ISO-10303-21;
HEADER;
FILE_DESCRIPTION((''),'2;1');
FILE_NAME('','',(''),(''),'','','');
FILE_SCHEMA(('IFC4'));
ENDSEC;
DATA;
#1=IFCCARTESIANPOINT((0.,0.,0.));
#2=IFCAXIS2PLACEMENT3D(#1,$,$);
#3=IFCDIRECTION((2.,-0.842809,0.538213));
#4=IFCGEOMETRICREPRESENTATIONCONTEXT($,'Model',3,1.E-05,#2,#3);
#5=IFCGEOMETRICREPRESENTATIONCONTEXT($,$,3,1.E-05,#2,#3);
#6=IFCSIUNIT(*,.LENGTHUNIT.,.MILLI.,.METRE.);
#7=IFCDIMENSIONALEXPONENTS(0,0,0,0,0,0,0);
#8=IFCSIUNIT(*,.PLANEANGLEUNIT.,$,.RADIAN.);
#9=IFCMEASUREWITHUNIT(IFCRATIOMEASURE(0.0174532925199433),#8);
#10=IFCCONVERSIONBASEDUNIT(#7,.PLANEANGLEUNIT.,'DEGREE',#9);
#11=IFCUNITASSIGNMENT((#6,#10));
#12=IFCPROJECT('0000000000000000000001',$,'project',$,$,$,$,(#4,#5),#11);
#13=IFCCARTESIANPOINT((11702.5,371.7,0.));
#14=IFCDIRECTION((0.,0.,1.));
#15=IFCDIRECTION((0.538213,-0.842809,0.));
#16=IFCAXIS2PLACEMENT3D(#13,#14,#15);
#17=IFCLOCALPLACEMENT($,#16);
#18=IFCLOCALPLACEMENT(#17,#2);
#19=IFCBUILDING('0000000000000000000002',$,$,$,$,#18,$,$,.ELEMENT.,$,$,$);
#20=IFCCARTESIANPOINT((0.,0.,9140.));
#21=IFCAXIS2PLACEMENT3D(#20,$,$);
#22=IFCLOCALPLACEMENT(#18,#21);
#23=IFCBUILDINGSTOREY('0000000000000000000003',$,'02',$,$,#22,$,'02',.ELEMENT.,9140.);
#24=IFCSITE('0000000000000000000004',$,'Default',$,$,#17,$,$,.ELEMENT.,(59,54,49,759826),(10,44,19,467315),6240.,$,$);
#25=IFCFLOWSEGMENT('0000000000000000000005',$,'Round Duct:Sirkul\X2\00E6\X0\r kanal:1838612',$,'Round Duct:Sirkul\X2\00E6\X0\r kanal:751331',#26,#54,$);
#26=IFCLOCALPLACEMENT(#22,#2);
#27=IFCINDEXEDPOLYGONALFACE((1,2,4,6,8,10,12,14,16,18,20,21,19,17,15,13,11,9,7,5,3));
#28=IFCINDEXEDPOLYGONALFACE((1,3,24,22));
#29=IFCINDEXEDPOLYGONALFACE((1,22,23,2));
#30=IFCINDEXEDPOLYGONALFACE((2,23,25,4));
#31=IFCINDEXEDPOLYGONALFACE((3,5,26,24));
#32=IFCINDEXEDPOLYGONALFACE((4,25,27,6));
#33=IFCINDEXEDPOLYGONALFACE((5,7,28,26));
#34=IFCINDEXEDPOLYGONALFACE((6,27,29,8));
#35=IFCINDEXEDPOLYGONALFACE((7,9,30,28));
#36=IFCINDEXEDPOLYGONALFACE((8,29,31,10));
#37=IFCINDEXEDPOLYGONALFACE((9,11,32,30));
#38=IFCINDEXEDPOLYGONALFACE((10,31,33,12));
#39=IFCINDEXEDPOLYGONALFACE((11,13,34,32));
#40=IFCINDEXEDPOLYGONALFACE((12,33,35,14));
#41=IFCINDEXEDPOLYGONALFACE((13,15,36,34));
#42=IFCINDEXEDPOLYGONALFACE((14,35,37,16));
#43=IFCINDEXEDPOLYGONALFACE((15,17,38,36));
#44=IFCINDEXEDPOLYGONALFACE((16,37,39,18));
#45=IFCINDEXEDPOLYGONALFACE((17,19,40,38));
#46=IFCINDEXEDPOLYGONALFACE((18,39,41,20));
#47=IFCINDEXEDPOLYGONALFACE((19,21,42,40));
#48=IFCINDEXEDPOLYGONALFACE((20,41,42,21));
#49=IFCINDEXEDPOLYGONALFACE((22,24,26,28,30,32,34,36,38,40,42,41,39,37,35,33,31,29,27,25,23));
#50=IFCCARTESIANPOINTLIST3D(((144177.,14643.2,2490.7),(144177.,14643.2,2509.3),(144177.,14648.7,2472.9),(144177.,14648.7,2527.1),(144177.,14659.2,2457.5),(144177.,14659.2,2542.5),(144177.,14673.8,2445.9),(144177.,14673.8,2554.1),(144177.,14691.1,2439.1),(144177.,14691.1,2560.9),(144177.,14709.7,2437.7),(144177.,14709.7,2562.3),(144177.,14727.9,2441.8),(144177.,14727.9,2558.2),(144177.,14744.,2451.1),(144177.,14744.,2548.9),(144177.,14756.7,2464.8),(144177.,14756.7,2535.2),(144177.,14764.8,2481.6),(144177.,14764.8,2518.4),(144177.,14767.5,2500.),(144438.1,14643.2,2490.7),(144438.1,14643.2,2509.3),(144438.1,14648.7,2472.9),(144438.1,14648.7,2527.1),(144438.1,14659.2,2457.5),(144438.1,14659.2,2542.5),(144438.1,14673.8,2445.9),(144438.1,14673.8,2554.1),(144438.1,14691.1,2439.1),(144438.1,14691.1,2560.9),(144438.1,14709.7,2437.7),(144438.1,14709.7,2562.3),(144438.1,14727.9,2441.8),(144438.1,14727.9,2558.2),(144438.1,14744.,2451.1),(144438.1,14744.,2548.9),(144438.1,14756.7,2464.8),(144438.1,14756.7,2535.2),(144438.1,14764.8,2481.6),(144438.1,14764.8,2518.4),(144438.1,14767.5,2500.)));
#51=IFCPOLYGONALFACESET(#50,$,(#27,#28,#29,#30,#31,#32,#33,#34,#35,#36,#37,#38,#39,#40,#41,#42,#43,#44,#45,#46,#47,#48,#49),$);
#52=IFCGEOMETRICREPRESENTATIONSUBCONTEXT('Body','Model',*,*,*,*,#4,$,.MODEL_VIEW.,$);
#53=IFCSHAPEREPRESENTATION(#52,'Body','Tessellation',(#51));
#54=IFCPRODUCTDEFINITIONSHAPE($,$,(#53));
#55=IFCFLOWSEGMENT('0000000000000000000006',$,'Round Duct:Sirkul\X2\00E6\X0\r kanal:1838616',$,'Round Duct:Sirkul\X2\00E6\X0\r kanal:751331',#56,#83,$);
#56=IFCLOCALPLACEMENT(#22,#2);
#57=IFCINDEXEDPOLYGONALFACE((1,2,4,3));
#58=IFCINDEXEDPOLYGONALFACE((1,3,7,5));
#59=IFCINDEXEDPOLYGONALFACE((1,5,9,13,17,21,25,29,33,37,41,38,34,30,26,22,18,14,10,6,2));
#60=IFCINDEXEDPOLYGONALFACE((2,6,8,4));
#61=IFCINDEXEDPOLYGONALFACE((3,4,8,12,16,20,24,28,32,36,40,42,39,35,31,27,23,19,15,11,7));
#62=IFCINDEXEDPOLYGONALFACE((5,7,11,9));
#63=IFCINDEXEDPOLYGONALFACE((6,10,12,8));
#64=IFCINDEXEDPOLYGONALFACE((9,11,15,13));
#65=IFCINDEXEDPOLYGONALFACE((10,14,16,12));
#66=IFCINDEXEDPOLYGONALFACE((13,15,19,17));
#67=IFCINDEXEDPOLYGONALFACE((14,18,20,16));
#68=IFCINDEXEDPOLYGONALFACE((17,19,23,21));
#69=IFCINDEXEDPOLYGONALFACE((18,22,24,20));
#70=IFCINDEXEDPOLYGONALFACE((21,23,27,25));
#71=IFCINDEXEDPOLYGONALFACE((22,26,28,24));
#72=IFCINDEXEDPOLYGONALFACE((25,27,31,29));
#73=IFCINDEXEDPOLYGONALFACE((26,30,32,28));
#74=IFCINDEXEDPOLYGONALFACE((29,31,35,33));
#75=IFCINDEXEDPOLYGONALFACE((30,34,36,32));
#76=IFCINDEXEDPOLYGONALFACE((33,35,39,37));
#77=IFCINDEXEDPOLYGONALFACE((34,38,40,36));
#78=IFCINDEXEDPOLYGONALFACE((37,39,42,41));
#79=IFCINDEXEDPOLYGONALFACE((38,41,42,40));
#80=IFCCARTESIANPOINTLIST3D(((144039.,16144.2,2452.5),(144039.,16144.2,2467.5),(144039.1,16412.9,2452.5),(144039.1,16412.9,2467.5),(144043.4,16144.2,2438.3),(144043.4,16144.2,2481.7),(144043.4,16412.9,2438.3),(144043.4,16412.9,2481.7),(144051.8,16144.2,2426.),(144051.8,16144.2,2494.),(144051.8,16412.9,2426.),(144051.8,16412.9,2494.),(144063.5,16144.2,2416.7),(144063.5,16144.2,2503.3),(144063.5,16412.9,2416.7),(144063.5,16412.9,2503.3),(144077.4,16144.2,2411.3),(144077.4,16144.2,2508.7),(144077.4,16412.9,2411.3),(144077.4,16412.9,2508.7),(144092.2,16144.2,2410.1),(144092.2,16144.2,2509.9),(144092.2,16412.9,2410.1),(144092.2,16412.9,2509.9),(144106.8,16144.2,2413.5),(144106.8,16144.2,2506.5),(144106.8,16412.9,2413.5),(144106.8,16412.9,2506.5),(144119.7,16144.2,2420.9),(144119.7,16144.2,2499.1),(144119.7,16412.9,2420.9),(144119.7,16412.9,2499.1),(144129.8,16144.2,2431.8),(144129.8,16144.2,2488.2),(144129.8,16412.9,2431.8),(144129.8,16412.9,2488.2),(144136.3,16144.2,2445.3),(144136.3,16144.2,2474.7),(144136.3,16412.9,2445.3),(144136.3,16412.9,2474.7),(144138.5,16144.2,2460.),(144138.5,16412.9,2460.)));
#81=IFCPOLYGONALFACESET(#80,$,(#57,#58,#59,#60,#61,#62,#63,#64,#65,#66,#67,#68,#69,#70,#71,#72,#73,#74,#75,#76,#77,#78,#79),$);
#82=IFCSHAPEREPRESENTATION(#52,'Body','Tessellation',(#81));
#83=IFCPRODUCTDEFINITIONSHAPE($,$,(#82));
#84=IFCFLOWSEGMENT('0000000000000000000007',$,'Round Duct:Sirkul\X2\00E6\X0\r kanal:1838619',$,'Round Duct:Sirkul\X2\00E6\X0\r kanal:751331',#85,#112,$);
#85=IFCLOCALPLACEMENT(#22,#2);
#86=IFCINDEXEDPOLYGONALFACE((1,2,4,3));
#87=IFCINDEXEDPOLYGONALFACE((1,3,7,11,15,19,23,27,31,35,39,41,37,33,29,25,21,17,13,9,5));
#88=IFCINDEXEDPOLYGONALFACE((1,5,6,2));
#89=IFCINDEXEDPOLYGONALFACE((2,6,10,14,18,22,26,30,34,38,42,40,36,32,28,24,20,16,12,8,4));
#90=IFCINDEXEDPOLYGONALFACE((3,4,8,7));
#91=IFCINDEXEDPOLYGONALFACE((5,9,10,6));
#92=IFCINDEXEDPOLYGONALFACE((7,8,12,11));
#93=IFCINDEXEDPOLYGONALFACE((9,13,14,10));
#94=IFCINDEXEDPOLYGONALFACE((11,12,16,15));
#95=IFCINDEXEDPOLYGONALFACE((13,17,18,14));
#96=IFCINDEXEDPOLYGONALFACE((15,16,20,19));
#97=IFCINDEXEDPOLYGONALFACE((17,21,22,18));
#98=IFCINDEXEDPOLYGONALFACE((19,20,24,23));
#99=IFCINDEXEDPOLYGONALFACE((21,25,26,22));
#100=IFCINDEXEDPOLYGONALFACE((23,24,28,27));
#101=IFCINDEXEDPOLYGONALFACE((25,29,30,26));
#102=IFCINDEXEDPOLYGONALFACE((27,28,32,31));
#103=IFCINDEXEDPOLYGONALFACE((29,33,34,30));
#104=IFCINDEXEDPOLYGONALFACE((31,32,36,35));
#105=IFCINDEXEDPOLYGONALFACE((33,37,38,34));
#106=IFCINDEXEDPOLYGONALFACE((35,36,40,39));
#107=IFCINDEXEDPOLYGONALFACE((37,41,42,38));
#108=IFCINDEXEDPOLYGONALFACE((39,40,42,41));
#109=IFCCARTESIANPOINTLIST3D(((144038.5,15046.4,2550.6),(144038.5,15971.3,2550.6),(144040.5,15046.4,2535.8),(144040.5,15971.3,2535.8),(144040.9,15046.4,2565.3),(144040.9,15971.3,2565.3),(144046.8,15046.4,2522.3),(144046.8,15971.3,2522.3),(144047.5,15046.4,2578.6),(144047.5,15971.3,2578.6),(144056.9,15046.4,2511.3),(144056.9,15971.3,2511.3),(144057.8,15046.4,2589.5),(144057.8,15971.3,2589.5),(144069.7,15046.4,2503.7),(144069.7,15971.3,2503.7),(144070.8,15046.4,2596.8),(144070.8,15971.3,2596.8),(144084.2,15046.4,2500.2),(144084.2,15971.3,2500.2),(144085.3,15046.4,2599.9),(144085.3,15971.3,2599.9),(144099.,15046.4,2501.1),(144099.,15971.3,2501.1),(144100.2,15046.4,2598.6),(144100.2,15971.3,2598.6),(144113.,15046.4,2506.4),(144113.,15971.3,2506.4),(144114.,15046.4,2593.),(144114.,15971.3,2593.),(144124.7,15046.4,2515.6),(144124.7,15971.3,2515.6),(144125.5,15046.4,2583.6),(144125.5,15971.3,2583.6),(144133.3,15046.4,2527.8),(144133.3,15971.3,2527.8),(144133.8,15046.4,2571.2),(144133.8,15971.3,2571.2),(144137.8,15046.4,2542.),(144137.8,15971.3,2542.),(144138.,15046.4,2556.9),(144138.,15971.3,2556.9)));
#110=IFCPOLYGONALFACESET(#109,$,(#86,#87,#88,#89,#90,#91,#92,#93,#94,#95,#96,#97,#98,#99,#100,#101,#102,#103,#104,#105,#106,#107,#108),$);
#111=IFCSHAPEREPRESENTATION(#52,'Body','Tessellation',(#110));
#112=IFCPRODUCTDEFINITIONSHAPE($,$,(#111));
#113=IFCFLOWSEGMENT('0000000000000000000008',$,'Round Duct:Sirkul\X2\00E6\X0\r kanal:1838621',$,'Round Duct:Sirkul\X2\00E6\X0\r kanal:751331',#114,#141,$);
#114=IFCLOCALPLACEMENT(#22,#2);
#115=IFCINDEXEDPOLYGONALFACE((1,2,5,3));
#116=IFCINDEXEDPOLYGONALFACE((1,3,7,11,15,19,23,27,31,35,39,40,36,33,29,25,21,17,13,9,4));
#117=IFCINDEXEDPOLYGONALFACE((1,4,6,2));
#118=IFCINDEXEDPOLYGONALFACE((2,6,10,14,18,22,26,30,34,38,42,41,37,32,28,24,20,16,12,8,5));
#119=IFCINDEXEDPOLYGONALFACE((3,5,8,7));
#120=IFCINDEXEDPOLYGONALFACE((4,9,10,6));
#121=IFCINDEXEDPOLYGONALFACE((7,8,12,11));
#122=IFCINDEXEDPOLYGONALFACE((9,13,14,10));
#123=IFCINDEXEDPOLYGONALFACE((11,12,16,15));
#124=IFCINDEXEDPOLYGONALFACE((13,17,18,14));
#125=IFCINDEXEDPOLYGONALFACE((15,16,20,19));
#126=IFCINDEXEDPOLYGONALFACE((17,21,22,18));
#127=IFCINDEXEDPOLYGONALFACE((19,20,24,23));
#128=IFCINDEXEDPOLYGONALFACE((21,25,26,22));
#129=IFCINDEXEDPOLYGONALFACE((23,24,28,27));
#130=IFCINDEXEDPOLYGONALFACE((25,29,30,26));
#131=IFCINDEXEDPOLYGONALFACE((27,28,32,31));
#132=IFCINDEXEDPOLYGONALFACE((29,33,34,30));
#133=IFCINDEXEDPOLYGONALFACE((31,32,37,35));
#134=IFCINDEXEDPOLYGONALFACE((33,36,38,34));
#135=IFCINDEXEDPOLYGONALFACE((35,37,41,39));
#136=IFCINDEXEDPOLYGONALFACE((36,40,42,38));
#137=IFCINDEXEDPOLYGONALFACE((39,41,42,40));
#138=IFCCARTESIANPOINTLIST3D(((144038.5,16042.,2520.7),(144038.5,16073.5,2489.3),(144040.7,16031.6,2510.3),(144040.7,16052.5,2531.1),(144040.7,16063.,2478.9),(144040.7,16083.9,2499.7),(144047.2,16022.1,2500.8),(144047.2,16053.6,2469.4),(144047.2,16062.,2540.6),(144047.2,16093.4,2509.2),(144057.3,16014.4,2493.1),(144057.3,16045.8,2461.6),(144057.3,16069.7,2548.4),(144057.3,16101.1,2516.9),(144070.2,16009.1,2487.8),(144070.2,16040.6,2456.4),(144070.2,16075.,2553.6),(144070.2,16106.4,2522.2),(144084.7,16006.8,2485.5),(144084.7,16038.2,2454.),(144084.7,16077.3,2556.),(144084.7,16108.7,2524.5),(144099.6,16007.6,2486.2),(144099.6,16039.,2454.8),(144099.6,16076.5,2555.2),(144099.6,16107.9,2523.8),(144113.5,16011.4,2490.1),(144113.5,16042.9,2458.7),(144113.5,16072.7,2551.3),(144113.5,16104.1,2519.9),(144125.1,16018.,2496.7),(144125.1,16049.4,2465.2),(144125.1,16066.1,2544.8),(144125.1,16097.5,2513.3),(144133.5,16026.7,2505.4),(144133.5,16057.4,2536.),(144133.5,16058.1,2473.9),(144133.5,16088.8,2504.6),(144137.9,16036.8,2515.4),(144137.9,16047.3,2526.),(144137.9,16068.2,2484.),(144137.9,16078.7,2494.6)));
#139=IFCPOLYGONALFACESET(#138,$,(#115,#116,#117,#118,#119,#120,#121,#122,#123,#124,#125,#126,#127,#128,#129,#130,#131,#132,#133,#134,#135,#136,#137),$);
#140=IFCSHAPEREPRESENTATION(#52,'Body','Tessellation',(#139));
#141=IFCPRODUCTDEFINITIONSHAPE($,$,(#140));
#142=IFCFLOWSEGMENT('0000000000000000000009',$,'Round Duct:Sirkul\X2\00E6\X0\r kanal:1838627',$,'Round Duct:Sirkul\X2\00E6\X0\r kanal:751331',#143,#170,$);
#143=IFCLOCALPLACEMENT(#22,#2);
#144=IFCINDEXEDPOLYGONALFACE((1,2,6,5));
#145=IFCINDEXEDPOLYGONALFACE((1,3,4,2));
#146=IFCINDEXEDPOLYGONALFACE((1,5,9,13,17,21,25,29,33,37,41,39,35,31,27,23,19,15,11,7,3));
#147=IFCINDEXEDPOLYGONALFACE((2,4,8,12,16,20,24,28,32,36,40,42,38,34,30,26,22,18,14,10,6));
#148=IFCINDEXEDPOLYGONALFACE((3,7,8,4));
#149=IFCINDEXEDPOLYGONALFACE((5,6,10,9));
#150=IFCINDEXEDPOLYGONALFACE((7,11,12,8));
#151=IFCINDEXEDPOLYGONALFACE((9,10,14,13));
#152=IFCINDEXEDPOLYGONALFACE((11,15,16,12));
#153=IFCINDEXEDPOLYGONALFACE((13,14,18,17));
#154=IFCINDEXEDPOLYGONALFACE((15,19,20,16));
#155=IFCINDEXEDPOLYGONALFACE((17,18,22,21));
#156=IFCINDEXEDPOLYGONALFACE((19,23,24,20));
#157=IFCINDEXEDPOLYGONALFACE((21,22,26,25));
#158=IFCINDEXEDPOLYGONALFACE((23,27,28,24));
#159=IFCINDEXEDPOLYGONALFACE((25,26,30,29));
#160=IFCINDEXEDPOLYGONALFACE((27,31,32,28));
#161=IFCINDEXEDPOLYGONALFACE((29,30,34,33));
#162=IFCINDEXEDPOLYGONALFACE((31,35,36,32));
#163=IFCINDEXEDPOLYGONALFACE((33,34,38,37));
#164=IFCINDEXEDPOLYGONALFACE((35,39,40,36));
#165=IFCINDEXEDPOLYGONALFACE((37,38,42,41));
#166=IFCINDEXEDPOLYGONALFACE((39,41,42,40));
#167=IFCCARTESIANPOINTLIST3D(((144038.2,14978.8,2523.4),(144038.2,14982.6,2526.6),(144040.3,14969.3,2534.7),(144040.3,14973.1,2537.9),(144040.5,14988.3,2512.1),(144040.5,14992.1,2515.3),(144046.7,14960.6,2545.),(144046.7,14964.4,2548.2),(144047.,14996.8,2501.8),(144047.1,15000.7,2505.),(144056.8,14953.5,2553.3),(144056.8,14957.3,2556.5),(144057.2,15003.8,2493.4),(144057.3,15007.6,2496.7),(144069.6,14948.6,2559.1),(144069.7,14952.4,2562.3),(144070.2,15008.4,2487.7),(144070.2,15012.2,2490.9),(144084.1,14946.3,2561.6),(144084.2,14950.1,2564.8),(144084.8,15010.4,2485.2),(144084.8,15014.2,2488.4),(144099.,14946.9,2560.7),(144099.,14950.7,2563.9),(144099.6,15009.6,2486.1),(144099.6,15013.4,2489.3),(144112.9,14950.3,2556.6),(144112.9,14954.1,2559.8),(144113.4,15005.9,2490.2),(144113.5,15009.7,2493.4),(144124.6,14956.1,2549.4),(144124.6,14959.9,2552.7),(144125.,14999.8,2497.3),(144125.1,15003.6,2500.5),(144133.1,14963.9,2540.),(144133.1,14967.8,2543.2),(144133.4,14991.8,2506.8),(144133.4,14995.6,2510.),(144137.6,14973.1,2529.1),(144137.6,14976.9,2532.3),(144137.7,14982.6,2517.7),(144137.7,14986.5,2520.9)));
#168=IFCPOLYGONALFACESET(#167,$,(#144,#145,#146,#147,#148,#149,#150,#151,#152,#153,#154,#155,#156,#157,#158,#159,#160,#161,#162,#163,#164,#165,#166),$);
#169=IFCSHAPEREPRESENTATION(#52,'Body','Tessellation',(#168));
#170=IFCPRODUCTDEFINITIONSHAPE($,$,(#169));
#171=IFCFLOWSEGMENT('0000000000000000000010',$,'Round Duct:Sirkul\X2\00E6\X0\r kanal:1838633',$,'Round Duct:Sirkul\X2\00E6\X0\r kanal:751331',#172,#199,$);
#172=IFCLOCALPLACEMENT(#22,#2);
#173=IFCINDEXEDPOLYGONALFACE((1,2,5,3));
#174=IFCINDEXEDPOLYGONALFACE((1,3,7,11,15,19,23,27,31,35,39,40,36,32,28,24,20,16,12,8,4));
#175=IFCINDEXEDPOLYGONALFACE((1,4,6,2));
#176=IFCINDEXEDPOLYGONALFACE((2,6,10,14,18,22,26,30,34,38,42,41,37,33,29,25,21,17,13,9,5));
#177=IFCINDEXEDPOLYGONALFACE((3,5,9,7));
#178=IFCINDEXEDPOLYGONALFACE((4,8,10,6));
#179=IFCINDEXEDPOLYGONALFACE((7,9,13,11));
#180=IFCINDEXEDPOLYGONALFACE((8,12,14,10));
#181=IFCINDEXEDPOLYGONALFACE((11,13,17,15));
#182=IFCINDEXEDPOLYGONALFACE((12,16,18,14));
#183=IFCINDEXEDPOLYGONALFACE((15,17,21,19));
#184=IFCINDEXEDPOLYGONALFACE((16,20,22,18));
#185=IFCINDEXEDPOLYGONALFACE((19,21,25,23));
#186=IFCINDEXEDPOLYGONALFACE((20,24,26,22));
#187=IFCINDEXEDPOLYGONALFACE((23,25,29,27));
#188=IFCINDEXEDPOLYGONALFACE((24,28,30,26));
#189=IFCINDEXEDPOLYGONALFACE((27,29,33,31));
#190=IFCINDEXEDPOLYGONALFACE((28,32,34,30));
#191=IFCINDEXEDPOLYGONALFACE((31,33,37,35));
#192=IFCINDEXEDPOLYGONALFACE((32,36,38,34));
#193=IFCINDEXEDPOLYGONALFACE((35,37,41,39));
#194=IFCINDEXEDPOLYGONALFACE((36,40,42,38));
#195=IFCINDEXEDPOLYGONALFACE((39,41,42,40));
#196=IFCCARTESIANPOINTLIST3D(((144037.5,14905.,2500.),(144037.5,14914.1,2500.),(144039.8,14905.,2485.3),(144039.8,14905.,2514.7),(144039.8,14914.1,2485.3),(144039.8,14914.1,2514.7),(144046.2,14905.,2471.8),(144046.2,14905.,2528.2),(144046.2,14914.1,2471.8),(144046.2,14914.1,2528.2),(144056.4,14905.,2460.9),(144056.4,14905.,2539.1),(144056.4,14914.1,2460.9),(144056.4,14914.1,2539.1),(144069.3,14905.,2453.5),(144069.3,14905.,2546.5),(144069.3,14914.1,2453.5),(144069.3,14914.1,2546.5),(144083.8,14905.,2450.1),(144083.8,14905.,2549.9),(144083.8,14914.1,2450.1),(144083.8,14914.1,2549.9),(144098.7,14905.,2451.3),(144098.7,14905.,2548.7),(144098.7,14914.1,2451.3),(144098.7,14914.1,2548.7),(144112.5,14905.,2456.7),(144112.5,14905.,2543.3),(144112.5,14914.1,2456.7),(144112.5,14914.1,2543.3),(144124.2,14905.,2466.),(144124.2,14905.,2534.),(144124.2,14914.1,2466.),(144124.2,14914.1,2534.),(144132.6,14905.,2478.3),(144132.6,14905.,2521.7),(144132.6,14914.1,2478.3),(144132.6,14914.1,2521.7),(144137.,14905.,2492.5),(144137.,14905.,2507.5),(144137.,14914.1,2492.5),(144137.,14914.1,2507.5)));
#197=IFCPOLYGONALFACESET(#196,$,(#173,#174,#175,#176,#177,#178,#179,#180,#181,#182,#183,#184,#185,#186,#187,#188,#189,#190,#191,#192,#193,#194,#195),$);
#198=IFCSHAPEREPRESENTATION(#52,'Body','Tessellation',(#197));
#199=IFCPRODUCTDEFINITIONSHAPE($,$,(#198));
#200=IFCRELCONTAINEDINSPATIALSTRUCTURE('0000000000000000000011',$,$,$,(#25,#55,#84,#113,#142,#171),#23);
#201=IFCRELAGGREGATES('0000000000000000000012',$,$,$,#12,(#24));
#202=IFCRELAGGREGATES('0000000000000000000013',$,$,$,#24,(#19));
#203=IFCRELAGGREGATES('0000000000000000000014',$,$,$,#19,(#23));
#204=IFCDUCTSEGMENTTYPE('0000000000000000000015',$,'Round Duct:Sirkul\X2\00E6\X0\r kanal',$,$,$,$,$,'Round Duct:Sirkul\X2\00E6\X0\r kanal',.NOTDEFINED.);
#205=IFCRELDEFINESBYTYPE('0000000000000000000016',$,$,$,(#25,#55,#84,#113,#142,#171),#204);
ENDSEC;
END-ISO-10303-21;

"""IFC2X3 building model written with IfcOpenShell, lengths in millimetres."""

from ifc_helpers import new_model, entity, si_unit, converted_unit, direction, frame, frame_2d, origin, origin_2d_with_axis, place, context, subcontext, project, spatial, circle, extrude, type_object, element, save


model = new_model("IFC2X3")

# Units and contexts
model_context = context("Model", 3, precision=1e-05, world=origin(), true_north=direction((2.0, -0.842809, 0.538213)))
context_of_model = context(None, 3, precision=1e-05, world=origin(), true_north=direction((2.0, -0.842809, 0.538213)))
body_context = subcontext(model_context, "Body", "Model", "MODEL_VIEW")
ifc_project = project(units=[si_unit("LENGTHUNIT", "METRE", prefix="MILLI"), converted_unit("PLANEANGLEUNIT", "DEGREE", entity("IfcRatioMeasure", 0.0174532925199433), si_unit("PLANEANGLEUNIT", "RADIAN"), dimensions=[0, 0, 0, 0, 0, 0, 0])], contexts=[model_context, context_of_model])

# Site, building, storey
site_placement = place(None, frame((11702.5, 371.7, 0.0), z_axis=(0.0, 0.0, 1.0), x_axis=(0.538213, -0.842809, 0.0)))
site = spatial("IfcSite", under=ifc_project, at=site_placement, Name="Default", CompositionType="ELEMENT", RefLatitude=(59, 54, 49, 759826), RefLongitude=(10, 44, 19, 467315), RefElevation=6240.0)
building_placement = place(site_placement, origin())
building = spatial("IfcBuilding", under=site, at=building_placement, CompositionType="ELEMENT")
storey_placement = place(building_placement, frame((0.0, 0.0, 9140.0)))
storey = spatial("IfcBuildingStorey", under=building, at=storey_placement, Name="02", LongName="02", CompositionType="ELEMENT", Elevation=9140.0)

# Flow segments
duct_segment_type_1 = type_object("IfcDuctSegmentType", Name="Round Duct:Sirkulær kanal", ElementType="Round Duct:Sirkulær kanal", PredefinedType="NOTDEFINED")
flow_segment_1_placement = place(storey_placement, origin())
element("IfcFlowSegment", 1, at=flow_segment_1_placement, inside=storey, type_object=duct_segment_type_1, Name="Round Duct:Sirkulær kanal:1838612", ObjectType="Round Duct:Sirkulær kanal:751331", context=body_context, shape_type="SweptSolid", body=[
    extrude(circle(Radius=62.5, at=origin_2d_with_axis()), frame((144177.0, 14705.0, 2500.0), z_axis=(1.0, 0.0, 0.0), x_axis=(0.0, 1.0, 0.0)), (0.0, 0.0, 1.0), 261.0),
])
flow_segment_2_placement = place(storey_placement, origin())
element("IfcFlowSegment", 2, at=flow_segment_2_placement, inside=storey, type_object=duct_segment_type_1, Name="Round Duct:Sirkulær kanal:1838616", ObjectType="Round Duct:Sirkulær kanal:751331", context=body_context, shape_type="SweptSolid", body=[
    extrude(circle(Radius=50.0, at=origin_2d_with_axis()), frame((144088.5, 16144.2, 2460.0), z_axis=(0.000037, 1.0, 0.0), x_axis=(1.0, -0.000037, 0.0)), (0.0, 0.0, 1.0), 268.8),
])
flow_segment_3_placement = place(storey_placement, origin())
element("IfcFlowSegment", 3, at=flow_segment_3_placement, inside=storey, type_object=duct_segment_type_1, Name="Round Duct:Sirkulær kanal:1838619", ObjectType="Round Duct:Sirkulær kanal:751331", context=body_context, shape_type="SweptSolid", body=[
    extrude(circle(Radius=50.0, at=frame_2d((0.0, 0.0), x_axis=(1.0, 0.0))), frame((144088.5, 15971.3, 2550.0), z_axis=(0.0, -1.0, 0.0), x_axis=(-0.999932, 0.0, 0.011691)), (0.0, 0.0, 1.0), 924.9),
])
flow_segment_4_placement = place(storey_placement, origin())
element("IfcFlowSegment", 4, at=flow_segment_4_placement, inside=storey, type_object=duct_segment_type_1, Name="Round Duct:Sirkulær kanal:1838621", ObjectType="Round Duct:Sirkulær kanal:751331", context=body_context, shape_type="SweptSolid", body=[
    extrude(circle(Radius=50.0, at=origin_2d_with_axis()), frame((144088.5, 16042.0, 2520.7), z_axis=(0.0, 0.707106, -0.707107), x_axis=(-1.0, 0.0, 0.0)), (0.0, 0.0, 1.0), 44.4),
])
flow_segment_5_placement = place(storey_placement, origin())
element("IfcFlowSegment", 5, at=flow_segment_5_placement, inside=storey, type_object=duct_segment_type_1, Name="Round Duct:Sirkulær kanal:1838627", ObjectType="Round Duct:Sirkulær kanal:751331", context=body_context, shape_type="SweptSolid", body=[
    extrude(circle(Radius=50.0, at=frame_2d((0.0, 0.0), x_axis=(1.0, 0.0))), frame((144088.2, 14978.3, 2523.4), z_axis=(0.007515, 0.766008, 0.642788), x_axis=(-0.999952, 0.00981, 0.0)), (0.0, 0.0, 1.0), 5.0),
])
flow_segment_6_placement = place(storey_placement, origin())
element("IfcFlowSegment", 6, at=flow_segment_6_placement, inside=storey, type_object=duct_segment_type_1, Name="Round Duct:Sirkulær kanal:1838633", ObjectType="Round Duct:Sirkulær kanal:751331", context=body_context, shape_type="SweptSolid", body=[
    extrude(circle(Radius=50.0, at=origin_2d_with_axis()), frame((144087.5, 14905.0, 2500.0), z_axis=(0.0, 1.0, 0.0), x_axis=(-1.0, 0.0, 0.0)), (0.0, 0.0, 1.0), 9.0),
])

save(model, "model.ifc")
